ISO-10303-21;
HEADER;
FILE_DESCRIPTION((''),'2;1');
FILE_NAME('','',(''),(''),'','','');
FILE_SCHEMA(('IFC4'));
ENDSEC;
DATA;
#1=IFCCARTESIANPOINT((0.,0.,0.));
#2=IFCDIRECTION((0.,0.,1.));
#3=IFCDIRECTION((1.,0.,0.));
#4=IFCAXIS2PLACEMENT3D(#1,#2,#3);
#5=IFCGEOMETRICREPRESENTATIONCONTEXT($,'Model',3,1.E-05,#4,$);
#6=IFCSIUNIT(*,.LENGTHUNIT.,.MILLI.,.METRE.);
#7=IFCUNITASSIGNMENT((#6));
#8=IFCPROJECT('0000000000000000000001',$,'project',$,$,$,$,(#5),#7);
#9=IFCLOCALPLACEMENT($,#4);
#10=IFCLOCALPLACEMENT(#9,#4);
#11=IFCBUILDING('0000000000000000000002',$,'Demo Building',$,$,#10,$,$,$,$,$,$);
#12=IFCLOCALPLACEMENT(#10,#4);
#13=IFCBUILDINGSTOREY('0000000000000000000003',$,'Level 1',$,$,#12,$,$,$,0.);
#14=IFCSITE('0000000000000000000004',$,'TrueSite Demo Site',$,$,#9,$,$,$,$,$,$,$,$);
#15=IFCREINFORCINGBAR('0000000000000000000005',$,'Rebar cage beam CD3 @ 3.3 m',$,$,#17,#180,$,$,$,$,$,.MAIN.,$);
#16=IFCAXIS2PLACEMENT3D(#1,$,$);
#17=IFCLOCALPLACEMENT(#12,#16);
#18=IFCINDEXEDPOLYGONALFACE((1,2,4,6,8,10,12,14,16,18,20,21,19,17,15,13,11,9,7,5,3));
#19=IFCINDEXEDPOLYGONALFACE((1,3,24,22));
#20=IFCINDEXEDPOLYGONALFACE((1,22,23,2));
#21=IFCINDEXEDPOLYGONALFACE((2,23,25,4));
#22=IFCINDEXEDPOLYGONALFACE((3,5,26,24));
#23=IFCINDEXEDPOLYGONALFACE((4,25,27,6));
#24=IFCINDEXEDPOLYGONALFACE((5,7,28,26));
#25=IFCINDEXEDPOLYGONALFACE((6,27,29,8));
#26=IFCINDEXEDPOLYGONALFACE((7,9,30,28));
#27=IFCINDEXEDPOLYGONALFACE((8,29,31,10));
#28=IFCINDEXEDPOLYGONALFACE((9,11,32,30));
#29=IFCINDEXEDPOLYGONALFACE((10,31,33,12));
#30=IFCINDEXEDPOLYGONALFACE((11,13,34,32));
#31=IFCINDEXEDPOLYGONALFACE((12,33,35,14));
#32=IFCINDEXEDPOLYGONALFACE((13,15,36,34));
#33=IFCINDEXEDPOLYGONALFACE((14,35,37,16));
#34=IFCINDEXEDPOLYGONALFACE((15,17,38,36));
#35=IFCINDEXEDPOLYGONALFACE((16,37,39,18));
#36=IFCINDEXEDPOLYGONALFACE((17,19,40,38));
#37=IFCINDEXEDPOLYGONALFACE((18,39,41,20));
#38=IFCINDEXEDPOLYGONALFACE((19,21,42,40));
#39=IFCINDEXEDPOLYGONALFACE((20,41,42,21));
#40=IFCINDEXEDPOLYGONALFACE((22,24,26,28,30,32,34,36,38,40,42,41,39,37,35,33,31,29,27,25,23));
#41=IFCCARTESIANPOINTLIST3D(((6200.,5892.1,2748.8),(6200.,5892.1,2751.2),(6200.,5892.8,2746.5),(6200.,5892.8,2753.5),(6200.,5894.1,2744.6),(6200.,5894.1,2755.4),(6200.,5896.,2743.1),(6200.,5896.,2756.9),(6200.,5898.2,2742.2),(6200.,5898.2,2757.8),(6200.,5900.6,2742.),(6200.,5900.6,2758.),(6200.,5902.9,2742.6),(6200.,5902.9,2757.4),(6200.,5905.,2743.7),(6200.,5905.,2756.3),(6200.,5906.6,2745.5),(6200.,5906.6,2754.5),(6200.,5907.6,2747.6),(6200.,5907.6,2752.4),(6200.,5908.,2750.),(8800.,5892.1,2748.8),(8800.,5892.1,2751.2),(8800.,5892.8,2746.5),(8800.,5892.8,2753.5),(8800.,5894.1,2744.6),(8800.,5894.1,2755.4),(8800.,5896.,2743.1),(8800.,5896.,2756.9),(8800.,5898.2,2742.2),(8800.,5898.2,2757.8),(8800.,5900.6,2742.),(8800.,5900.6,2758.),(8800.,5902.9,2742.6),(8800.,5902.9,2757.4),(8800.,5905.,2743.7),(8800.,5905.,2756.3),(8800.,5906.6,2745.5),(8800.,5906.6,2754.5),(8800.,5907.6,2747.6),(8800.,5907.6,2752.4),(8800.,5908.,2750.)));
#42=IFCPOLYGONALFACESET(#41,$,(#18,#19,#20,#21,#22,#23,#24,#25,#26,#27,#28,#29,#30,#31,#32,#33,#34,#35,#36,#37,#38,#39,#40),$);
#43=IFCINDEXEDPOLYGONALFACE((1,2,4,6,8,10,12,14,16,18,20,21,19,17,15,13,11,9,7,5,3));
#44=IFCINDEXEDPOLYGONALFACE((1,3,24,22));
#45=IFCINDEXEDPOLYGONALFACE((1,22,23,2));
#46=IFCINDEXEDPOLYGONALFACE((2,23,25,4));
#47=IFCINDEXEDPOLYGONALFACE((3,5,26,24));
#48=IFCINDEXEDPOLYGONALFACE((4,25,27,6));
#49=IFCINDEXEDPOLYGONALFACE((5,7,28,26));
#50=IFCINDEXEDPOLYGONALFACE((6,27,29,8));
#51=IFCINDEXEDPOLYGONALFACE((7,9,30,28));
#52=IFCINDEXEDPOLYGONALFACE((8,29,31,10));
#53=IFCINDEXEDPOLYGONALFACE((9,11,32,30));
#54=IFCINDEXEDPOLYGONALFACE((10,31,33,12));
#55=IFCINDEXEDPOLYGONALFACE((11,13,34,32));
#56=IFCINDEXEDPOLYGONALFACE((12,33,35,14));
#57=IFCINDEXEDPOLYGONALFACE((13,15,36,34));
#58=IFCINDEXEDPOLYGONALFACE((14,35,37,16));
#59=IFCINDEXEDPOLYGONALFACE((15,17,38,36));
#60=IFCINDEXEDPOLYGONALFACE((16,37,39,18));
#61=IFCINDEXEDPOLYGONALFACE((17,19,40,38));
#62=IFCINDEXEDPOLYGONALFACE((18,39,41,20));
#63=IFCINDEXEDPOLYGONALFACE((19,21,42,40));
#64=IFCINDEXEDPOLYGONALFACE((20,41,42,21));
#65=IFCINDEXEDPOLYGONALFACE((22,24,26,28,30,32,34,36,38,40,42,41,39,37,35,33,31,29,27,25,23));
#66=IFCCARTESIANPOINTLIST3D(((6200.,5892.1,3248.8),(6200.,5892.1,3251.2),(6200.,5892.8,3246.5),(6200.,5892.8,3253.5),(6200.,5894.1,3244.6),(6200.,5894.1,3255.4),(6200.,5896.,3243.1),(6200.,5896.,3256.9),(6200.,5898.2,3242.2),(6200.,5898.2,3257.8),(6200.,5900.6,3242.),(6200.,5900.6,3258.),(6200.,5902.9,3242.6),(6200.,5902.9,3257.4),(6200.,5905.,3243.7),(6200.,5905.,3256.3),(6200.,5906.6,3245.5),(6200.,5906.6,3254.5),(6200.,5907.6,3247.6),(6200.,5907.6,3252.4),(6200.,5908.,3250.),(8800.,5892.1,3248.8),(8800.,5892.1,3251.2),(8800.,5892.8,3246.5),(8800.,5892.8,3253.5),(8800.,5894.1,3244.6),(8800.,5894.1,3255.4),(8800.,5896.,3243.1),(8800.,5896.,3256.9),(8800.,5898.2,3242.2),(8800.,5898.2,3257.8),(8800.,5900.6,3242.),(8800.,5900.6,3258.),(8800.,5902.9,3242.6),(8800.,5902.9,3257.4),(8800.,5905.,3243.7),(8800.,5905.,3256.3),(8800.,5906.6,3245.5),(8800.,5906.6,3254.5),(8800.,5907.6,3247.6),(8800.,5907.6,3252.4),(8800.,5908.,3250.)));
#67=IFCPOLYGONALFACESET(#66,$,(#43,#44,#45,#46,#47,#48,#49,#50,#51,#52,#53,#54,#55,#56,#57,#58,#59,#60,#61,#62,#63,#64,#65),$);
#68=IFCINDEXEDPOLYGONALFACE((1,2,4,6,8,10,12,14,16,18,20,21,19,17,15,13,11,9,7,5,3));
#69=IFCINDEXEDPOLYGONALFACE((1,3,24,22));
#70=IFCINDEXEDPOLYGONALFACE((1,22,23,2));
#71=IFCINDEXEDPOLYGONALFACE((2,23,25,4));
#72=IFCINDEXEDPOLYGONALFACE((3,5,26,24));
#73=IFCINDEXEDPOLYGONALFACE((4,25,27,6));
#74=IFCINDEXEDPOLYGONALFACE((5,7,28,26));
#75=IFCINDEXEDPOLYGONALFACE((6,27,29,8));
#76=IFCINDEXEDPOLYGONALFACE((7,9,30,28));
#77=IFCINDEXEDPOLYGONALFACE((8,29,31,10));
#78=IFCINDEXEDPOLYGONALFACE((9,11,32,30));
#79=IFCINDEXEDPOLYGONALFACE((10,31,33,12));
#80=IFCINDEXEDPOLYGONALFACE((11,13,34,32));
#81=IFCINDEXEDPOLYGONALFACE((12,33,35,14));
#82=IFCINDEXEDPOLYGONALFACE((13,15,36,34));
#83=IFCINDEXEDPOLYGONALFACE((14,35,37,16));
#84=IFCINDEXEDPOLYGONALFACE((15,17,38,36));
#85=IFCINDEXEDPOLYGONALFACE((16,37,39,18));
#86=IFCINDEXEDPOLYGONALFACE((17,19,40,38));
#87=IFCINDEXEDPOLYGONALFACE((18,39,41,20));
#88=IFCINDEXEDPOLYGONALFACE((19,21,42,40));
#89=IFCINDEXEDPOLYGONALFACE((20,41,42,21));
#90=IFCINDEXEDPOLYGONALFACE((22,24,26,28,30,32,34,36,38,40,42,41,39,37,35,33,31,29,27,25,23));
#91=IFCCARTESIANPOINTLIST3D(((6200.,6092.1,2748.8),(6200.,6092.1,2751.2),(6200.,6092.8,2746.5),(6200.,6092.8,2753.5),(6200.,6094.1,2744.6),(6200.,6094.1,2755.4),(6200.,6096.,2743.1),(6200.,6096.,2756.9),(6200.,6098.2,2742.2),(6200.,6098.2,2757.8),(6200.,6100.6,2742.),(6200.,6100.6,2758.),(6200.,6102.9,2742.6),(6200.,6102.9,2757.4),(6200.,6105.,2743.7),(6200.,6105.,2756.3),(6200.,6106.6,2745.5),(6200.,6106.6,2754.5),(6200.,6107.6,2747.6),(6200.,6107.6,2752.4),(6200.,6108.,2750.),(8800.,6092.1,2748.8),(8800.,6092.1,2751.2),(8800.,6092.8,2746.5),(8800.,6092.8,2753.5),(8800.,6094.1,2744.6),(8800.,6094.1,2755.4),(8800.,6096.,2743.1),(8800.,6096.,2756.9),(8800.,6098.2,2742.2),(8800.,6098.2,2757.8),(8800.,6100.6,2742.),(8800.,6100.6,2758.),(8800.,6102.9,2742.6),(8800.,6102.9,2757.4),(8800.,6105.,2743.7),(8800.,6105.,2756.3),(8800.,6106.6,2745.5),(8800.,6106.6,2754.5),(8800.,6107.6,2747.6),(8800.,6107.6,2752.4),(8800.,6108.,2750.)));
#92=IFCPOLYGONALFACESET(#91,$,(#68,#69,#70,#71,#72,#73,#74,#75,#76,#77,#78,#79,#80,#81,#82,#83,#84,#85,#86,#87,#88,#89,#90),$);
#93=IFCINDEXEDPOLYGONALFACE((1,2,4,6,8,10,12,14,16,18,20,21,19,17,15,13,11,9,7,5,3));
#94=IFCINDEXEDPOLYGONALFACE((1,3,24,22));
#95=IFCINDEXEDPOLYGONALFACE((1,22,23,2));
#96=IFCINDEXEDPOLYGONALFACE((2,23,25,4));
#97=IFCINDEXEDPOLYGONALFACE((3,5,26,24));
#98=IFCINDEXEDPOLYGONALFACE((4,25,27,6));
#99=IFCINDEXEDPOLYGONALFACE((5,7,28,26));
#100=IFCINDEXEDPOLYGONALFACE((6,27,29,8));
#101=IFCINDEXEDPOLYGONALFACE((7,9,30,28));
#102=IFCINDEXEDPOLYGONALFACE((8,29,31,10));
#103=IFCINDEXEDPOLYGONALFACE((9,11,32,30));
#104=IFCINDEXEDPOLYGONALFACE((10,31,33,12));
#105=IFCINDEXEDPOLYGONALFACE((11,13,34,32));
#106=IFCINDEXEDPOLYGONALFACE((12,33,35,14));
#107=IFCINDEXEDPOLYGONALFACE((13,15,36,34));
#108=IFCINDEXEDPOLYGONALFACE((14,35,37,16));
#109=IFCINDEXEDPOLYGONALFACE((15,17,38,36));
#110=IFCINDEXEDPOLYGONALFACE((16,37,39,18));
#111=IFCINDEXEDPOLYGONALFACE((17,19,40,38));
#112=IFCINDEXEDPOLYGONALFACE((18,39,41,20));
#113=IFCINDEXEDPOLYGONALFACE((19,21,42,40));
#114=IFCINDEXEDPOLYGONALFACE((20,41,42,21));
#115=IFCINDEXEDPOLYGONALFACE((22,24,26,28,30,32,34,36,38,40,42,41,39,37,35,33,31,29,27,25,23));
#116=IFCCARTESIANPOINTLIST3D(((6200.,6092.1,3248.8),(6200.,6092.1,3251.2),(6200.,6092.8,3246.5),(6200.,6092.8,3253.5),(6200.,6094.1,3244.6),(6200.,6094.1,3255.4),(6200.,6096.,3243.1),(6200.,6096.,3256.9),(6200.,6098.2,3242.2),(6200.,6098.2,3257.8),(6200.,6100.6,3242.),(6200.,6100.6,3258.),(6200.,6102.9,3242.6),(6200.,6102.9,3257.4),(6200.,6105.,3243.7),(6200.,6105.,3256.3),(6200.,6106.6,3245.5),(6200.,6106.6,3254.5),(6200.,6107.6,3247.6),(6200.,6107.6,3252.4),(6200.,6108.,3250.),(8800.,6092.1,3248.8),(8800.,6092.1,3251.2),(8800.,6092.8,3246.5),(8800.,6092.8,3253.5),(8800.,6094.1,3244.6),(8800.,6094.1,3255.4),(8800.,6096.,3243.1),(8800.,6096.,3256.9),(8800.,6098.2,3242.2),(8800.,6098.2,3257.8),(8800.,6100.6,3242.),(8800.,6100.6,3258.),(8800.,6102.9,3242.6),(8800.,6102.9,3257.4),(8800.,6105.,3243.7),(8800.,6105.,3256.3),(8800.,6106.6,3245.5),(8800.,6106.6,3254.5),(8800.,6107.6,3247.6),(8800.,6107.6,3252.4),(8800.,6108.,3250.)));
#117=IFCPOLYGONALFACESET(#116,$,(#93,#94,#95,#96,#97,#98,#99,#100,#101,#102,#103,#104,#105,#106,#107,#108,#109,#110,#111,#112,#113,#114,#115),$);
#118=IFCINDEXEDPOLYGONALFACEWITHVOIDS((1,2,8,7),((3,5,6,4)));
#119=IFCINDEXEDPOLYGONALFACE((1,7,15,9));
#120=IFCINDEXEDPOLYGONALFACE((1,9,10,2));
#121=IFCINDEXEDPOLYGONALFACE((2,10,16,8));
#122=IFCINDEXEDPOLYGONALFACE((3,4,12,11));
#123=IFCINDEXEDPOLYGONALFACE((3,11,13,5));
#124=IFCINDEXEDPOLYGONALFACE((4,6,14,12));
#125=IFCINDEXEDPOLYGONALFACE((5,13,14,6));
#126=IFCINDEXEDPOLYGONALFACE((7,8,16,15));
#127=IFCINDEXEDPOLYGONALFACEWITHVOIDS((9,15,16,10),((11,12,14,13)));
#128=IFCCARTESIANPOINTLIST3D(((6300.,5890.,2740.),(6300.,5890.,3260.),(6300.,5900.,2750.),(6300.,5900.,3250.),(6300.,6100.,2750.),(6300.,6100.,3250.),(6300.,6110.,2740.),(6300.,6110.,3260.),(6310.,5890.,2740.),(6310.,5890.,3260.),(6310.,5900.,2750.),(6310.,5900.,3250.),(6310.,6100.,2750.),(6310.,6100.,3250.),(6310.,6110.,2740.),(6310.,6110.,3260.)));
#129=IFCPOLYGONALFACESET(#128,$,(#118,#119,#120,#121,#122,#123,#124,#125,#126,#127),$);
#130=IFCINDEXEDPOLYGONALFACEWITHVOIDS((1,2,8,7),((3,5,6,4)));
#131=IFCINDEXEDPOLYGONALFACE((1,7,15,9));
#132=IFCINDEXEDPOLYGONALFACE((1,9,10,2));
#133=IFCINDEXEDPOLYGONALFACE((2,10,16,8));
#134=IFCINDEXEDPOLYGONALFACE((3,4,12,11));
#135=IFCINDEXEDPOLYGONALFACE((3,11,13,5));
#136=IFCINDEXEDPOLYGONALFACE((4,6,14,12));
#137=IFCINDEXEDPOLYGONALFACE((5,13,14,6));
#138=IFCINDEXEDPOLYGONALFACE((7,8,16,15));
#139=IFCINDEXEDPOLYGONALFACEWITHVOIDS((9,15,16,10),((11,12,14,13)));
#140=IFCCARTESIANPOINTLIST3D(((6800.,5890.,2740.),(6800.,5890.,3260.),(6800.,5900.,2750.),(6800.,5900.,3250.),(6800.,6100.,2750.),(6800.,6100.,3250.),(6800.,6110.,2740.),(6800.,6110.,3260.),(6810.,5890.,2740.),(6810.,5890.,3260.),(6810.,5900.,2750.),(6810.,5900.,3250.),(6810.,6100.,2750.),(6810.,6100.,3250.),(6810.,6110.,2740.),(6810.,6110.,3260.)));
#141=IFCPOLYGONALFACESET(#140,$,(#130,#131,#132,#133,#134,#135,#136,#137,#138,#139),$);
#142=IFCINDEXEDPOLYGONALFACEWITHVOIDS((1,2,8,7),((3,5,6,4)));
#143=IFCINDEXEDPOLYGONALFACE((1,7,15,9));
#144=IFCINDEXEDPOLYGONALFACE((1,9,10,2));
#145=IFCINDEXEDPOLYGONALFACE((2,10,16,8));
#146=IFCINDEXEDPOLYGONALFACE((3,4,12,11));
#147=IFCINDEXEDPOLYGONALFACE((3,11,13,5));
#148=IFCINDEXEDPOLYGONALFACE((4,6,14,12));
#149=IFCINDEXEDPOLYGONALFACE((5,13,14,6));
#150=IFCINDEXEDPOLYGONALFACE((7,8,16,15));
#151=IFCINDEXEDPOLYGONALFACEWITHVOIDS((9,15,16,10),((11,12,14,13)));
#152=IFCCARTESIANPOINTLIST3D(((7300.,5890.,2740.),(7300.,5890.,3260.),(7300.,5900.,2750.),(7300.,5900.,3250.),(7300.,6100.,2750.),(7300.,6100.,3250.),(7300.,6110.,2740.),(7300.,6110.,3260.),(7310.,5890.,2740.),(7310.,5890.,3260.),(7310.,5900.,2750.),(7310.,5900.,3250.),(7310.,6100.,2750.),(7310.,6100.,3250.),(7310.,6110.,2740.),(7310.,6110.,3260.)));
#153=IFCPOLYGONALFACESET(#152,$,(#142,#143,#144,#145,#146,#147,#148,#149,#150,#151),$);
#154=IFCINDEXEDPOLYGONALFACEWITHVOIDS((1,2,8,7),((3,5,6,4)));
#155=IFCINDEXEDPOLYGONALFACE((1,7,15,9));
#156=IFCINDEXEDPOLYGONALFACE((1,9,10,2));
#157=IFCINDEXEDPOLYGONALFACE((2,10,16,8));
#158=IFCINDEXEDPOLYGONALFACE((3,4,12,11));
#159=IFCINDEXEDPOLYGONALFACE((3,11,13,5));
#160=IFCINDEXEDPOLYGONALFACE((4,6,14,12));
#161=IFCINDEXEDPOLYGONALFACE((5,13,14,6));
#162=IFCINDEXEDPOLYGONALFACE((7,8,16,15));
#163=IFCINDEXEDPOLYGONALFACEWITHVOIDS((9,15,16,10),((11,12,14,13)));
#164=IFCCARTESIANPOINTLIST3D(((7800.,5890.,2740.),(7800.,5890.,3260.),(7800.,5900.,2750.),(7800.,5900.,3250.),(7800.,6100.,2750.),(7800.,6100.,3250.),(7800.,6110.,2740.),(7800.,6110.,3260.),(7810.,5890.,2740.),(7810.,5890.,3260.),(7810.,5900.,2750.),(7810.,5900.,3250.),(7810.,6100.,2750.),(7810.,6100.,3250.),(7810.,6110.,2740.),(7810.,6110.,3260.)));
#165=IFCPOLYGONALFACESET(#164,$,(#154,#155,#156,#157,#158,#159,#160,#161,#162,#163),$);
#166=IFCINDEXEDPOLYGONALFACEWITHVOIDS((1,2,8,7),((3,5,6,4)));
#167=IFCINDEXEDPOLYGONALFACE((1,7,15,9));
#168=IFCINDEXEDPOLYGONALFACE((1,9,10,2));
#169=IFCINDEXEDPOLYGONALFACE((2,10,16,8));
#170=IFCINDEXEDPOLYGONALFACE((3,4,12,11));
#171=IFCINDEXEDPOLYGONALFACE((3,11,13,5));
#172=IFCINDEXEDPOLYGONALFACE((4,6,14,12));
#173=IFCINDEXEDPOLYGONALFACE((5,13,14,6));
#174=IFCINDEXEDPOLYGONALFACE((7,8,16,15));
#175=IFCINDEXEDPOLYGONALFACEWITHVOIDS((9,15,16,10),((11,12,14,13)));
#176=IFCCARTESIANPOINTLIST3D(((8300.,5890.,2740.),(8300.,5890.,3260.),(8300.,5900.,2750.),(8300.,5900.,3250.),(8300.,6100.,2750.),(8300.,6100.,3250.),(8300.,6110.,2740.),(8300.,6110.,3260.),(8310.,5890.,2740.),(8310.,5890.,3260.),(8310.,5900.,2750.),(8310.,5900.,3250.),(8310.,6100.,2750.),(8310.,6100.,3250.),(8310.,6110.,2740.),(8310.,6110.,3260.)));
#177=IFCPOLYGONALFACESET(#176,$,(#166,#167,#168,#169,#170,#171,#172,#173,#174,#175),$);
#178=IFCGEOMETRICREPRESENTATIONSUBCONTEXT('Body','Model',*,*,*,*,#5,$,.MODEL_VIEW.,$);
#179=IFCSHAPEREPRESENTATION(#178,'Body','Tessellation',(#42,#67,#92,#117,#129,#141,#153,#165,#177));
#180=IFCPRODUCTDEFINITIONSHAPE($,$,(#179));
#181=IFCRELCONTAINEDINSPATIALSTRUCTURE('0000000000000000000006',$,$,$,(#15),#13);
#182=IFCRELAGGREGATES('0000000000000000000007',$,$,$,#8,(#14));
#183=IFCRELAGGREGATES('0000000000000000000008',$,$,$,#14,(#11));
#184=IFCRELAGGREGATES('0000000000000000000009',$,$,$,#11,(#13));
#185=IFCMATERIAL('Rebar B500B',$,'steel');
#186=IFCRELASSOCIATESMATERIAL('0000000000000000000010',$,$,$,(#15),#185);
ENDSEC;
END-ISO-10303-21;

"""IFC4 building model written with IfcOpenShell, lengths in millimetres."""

from ifc_helpers import new_model, si_unit, frame, origin_with_axes, place, context, subcontext, project, spatial, hollow_rectangle, circle, extrude, material, element, save


model = new_model("IFC4")

# Units and contexts
model_context = context("Model", 3, precision=1e-05, world=origin_with_axes())
body_context = subcontext(model_context, "Body", "Model", "MODEL_VIEW")
ifc_project = project(units=[si_unit("LENGTHUNIT", "METRE", prefix="MILLI")], contexts=[model_context])

# Site, building, storey
site_placement = place(None, origin_with_axes())
site = spatial("IfcSite", under=ifc_project, at=site_placement, Name="TrueSite Demo Site")
building_placement = place(site_placement, origin_with_axes())
building = spatial("IfcBuilding", under=site, at=building_placement, Name="Demo Building")
storey_placement = place(building_placement, origin_with_axes())
storey = spatial("IfcBuildingStorey", under=building, at=storey_placement, Name="Level 1", Elevation=0.0)

# Reinforcing bar
ifc_material_1 = material(Name="Rebar B500B", Category="steel")
for number, where, z_axis, x_axis, name in (
    (1, (6200.0, 6000.0, 3000.0), (1.0, 0.0, 0.0), (0.0, 1.0, 0.0), "Rebar cage beam CD3 @ 3.3 m"),
):
    element("IfcReinforcingBar", number, at=place(storey_placement, frame(where, z_axis=z_axis, x_axis=x_axis)), inside=storey, material=ifc_material_1, Name=name, PredefinedType="MAIN", context=body_context, shape_type="SweptSolid", body=[
        extrude(circle(Radius=8.0), frame((-100.0, -250.0, 0.0)), (0.0, 0.0, 1.0), 2600.0),
        extrude(circle(Radius=8.0), frame((-100.0, 250.0, 0.0)), (0.0, 0.0, 1.0), 2600.0),
        extrude(circle(Radius=8.0), frame((100.0, -250.0, 0.0)), (0.0, 0.0, 1.0), 2600.0),
        extrude(circle(Radius=8.0), frame((100.0, 250.0, 0.0)), (0.0, 0.0, 1.0), 2600.0),
        extrude(hollow_rectangle(XDim=220.0, YDim=520.0, WallThickness=10.0), frame((0.0, 0.0, 100.0)), (0.0, 0.0, 1.0), 10.0),
        extrude(hollow_rectangle(XDim=220.0, YDim=520.0, WallThickness=10.0), frame((0.0, 0.0, 600.0)), (0.0, 0.0, 1.0), 10.0),
        extrude(hollow_rectangle(XDim=220.0, YDim=520.0, WallThickness=10.0), frame((0.0, 0.0, 1100.0)), (0.0, 0.0, 1.0), 10.0),
        extrude(hollow_rectangle(XDim=220.0, YDim=520.0, WallThickness=10.0), frame((0.0, 0.0, 1600.0)), (0.0, 0.0, 1.0), 10.0),
        extrude(hollow_rectangle(XDim=220.0, YDim=520.0, WallThickness=10.0), frame((0.0, 0.0, 2100.0)), (0.0, 0.0, 1.0), 10.0),
    ])

save(model, "model.ifc")
